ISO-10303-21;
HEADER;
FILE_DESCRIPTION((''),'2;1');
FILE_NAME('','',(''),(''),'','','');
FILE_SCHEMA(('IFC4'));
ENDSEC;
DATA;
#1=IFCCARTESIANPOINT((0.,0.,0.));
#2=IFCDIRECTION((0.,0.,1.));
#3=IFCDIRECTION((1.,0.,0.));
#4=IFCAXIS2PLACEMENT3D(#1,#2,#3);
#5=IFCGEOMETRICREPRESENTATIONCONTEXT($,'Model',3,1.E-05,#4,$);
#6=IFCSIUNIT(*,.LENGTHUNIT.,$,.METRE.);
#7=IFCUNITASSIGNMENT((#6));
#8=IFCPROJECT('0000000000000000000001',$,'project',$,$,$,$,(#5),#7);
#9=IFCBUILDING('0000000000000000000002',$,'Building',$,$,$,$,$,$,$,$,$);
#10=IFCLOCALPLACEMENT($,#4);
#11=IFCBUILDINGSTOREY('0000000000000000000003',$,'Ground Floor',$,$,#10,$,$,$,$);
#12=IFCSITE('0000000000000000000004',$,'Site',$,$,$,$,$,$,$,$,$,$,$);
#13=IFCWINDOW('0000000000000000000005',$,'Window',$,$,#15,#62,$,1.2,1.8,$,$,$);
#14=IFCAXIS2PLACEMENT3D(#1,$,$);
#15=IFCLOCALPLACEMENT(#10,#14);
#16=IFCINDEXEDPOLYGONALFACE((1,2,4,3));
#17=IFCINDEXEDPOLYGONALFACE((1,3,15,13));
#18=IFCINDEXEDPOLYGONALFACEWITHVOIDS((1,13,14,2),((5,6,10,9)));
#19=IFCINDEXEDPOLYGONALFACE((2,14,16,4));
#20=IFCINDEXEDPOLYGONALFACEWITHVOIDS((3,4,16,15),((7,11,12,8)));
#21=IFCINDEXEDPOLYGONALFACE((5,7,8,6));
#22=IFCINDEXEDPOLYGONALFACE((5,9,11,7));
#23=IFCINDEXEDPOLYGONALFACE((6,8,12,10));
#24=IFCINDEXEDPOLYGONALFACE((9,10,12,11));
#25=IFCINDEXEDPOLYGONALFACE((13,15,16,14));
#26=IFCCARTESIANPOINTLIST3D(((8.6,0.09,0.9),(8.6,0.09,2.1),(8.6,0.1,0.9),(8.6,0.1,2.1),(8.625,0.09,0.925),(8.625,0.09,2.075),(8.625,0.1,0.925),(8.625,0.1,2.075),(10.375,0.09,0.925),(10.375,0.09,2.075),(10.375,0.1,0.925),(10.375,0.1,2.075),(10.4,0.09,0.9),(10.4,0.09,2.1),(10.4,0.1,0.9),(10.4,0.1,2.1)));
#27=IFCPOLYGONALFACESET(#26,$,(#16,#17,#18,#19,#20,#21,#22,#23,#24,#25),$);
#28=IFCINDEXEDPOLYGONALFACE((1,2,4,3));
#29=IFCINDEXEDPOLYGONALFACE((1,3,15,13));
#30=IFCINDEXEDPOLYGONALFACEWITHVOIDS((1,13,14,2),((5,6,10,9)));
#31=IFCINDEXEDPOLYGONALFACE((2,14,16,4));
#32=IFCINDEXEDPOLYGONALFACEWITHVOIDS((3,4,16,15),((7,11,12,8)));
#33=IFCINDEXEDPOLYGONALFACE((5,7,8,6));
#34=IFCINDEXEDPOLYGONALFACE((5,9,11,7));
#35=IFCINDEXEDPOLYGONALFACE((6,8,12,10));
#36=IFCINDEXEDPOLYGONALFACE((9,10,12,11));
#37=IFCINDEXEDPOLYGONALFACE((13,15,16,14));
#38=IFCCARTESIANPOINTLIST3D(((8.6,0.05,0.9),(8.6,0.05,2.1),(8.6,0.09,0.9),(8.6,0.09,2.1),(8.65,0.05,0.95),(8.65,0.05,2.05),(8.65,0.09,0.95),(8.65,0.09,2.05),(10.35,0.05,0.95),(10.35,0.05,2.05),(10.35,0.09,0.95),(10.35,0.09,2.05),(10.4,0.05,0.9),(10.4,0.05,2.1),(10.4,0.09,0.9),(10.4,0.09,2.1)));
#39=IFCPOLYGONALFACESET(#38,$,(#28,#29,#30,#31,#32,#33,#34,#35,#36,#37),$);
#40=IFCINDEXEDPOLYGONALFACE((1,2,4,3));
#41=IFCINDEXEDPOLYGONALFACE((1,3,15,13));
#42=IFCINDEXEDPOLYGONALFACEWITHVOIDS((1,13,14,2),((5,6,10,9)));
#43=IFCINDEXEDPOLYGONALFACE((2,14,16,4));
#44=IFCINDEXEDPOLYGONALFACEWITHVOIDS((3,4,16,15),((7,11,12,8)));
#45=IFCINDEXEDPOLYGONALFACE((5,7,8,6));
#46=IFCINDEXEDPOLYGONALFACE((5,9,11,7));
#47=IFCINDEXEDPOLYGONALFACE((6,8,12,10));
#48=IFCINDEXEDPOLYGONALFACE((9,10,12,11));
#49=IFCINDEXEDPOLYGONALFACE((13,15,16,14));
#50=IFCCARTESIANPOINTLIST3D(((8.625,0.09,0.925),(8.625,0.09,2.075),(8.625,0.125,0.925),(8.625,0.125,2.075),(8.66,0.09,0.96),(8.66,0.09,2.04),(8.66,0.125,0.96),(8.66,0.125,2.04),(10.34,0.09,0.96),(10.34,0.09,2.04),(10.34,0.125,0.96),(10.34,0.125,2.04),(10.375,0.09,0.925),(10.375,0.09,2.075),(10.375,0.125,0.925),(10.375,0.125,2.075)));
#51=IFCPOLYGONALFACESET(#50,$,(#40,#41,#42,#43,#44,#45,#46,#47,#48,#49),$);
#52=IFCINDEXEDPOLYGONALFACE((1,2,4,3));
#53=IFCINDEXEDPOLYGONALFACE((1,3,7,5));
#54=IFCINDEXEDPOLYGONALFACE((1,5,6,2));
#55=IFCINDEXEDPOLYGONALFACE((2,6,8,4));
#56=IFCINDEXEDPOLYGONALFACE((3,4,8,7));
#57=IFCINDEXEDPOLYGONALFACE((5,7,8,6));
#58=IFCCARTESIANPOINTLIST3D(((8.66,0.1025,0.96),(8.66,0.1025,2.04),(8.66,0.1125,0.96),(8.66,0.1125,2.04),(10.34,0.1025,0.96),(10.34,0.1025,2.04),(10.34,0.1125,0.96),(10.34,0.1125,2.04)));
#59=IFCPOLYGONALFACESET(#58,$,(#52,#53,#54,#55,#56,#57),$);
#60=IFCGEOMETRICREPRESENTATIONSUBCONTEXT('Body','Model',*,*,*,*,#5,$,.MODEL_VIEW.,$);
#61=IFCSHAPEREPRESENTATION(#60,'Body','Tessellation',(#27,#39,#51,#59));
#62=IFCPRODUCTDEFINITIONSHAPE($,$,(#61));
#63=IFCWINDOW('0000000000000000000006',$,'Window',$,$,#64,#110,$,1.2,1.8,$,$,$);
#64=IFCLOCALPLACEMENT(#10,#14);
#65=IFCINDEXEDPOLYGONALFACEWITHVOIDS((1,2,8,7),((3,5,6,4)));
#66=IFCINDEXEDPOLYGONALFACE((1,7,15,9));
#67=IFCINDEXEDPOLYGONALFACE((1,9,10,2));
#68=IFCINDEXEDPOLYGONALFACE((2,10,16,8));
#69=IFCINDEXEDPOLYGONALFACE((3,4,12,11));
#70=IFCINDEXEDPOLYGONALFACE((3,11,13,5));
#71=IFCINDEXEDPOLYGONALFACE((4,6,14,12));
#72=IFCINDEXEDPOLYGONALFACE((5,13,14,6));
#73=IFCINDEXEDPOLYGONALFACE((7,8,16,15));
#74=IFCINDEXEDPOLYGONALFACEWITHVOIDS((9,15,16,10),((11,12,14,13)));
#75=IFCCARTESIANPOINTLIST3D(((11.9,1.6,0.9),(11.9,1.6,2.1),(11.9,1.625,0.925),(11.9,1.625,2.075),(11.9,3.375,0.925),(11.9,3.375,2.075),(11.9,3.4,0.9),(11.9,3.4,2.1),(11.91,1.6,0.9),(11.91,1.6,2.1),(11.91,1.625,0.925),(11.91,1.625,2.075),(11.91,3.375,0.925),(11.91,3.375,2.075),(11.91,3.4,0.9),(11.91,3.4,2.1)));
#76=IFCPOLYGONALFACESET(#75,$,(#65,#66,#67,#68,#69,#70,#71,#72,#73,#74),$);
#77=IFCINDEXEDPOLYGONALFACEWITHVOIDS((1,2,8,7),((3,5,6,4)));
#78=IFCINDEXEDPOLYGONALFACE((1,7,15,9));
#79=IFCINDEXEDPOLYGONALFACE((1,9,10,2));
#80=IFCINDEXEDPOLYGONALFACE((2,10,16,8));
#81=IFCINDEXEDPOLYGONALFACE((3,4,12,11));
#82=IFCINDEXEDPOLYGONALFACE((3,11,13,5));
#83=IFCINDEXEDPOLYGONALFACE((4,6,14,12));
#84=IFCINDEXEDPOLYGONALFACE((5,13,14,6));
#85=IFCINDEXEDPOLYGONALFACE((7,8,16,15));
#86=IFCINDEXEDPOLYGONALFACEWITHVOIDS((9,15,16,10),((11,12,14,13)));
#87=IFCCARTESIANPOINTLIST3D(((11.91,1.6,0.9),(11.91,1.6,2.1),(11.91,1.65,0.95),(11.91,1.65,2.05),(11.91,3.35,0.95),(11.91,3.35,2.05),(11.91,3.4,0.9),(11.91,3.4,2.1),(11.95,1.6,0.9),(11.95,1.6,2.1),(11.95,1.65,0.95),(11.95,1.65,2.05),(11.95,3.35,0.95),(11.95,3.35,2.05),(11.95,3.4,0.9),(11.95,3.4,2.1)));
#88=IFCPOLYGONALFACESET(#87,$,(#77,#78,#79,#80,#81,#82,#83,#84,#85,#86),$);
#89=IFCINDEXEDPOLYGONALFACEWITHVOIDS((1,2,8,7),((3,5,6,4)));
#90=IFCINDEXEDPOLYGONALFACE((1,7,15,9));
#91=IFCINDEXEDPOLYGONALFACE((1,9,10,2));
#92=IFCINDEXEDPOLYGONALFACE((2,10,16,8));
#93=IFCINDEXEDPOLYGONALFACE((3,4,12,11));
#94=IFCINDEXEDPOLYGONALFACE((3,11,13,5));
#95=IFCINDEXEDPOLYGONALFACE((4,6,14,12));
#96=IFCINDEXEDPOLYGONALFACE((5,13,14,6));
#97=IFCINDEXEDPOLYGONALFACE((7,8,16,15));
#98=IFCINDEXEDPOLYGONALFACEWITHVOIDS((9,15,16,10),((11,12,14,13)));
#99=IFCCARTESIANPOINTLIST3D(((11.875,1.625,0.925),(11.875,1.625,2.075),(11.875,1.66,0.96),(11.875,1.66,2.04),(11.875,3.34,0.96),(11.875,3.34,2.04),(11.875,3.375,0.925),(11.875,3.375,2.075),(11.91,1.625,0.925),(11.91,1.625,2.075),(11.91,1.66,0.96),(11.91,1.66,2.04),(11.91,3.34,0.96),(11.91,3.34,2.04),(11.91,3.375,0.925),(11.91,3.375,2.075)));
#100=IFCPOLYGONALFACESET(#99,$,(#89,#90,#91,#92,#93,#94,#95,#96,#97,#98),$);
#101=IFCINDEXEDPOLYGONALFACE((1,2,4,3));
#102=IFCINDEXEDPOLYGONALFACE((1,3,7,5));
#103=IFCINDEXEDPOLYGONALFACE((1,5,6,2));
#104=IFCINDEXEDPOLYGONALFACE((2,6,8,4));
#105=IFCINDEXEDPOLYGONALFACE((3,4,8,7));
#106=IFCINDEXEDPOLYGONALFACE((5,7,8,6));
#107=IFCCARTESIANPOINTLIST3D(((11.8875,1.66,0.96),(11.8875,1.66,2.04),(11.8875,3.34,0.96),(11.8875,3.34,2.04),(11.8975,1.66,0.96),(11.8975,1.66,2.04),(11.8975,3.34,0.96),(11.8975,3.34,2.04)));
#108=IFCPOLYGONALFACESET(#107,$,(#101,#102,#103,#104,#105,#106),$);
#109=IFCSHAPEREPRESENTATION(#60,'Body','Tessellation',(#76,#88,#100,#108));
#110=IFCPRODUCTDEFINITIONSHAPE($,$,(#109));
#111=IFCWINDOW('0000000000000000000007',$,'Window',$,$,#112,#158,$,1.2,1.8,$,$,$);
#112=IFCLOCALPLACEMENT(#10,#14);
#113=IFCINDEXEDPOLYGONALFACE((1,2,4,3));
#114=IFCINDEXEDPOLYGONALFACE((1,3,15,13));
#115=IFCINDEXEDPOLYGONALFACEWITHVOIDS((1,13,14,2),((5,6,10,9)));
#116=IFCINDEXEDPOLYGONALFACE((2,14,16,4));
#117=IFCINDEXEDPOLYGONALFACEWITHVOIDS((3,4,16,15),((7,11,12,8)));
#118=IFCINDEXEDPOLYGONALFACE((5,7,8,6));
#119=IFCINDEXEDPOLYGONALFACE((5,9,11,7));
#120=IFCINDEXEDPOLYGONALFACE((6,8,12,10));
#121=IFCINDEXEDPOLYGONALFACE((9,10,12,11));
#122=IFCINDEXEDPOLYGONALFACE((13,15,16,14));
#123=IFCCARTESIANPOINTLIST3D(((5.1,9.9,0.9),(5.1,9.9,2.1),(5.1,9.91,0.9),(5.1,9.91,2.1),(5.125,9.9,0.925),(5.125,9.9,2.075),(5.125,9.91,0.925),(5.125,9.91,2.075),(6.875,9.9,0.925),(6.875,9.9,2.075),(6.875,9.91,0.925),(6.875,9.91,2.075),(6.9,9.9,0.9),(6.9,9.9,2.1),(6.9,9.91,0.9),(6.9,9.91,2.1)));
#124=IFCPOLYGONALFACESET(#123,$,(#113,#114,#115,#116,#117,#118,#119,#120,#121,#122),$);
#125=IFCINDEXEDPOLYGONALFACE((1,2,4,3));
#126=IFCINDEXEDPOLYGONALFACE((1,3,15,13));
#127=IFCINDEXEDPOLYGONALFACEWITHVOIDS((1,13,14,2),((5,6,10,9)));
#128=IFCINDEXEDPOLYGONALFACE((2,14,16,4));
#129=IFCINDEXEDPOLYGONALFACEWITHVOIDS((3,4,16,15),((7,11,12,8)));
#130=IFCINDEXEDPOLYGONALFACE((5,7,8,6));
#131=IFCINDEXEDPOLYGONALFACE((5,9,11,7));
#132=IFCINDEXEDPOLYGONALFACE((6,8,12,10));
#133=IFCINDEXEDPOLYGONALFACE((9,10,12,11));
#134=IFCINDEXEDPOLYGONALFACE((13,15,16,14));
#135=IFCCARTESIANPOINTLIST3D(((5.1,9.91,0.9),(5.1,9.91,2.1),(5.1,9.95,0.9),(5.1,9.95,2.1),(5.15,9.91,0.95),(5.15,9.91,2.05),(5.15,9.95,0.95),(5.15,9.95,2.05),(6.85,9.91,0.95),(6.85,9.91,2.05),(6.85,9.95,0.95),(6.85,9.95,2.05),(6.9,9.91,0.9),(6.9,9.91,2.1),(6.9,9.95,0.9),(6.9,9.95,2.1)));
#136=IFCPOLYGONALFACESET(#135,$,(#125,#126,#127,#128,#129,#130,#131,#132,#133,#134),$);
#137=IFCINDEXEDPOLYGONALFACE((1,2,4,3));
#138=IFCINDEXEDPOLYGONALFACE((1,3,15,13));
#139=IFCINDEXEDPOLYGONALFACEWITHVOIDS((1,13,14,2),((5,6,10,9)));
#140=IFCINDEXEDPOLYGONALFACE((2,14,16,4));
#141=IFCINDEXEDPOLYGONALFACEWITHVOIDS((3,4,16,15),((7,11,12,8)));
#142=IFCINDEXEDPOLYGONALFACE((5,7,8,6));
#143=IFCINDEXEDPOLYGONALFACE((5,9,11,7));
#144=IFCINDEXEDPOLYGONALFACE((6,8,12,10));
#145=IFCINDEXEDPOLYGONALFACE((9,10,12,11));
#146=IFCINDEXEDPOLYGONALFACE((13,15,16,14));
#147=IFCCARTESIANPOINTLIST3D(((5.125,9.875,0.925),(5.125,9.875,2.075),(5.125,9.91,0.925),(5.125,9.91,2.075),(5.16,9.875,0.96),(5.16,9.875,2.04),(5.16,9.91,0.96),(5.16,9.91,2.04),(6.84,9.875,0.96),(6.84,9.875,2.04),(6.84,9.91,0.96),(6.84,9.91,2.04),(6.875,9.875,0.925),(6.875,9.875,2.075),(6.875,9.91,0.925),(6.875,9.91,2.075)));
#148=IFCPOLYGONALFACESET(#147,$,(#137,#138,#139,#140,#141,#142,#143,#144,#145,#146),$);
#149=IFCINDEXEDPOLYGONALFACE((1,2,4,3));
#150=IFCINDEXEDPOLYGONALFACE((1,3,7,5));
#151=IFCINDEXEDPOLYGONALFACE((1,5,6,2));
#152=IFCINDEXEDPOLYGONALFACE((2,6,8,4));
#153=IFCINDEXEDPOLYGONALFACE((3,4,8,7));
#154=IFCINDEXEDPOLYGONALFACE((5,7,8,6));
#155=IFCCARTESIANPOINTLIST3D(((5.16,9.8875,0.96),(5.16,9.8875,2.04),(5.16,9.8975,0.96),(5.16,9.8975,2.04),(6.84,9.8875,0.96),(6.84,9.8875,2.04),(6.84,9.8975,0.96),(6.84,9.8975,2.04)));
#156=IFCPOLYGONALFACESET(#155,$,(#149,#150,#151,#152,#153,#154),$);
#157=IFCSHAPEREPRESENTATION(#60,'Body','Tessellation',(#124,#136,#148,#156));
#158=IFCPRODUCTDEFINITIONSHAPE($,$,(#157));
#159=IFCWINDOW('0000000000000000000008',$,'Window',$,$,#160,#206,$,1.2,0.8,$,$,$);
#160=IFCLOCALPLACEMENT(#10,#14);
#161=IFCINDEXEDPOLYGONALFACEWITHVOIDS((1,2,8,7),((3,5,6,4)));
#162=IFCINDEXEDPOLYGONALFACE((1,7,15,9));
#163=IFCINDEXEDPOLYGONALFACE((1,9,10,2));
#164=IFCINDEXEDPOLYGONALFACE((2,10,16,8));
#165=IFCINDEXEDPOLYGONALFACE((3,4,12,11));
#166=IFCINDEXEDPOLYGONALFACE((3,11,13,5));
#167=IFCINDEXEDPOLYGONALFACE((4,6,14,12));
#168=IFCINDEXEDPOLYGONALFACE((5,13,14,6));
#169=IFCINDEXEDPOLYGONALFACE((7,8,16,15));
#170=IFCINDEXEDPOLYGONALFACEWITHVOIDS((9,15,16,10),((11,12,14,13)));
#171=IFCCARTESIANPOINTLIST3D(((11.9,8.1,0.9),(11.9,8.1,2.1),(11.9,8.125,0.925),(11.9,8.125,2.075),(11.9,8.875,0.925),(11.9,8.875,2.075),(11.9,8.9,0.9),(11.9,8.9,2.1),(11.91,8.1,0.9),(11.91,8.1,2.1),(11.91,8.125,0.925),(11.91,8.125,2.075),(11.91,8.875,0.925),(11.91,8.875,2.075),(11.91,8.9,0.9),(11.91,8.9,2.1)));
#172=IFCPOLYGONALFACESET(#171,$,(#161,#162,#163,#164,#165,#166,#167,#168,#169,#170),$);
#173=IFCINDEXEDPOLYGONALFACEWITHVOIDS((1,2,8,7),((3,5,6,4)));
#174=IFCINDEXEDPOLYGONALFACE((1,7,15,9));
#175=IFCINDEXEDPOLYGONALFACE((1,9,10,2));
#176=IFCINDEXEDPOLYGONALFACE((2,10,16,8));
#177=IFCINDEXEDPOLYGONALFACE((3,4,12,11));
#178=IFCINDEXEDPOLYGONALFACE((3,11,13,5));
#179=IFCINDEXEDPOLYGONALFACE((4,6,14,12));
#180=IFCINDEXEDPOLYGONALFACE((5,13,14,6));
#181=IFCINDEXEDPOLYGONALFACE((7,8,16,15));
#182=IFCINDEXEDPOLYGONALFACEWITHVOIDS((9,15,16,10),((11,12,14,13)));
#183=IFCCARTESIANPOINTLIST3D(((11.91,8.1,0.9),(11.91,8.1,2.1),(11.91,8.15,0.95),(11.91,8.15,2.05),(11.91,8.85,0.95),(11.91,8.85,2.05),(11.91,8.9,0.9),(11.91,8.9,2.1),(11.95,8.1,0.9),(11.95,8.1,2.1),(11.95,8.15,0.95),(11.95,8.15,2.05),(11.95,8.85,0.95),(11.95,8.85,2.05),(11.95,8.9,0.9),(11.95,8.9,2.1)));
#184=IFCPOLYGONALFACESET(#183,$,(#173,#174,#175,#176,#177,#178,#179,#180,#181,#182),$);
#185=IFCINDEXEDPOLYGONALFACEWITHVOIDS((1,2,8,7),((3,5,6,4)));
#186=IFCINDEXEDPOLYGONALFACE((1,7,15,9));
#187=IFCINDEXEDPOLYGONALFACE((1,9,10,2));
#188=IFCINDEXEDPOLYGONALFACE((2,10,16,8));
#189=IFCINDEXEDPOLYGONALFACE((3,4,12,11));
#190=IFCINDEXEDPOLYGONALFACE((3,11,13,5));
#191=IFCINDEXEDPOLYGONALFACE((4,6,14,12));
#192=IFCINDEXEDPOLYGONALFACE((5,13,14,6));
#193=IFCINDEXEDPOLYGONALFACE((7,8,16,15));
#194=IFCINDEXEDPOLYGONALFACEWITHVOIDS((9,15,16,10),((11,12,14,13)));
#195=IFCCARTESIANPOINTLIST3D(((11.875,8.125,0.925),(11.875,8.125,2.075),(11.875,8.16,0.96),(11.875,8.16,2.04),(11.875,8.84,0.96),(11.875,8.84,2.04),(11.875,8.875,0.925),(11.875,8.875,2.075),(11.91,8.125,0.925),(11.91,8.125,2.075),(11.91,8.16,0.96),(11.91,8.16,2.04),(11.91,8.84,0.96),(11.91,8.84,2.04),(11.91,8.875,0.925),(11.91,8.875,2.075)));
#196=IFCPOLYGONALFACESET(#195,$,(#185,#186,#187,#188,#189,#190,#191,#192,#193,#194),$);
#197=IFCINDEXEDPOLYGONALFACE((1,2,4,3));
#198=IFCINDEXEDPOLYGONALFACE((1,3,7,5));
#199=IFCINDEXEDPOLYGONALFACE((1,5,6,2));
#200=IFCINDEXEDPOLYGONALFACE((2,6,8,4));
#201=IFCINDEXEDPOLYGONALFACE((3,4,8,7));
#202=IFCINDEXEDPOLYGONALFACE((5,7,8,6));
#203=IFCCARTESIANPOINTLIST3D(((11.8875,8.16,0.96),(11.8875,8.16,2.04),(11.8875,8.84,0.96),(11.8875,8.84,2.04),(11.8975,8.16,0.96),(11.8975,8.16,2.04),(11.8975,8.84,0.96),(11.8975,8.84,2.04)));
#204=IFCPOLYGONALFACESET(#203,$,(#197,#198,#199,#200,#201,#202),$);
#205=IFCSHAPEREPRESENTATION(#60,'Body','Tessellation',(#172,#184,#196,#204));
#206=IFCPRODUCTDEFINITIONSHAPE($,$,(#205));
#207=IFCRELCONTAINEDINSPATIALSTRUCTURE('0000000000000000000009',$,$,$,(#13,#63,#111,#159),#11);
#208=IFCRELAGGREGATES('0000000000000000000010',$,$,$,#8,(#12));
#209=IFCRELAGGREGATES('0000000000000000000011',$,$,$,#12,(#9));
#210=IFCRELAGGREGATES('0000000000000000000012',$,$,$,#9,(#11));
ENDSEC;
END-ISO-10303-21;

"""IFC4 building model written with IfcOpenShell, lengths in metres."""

from ifc_helpers import new_model, si_unit, frame, origin_with_axes, place, context, subcontext, project, spatial, line, indexed_curve, outline, extrude, element, save


model = new_model("IFC4")

# Units and contexts
model_context = context("Model", 3, precision=1e-05, world=origin_with_axes())
body_context = subcontext(model_context, "Body", "Model", "MODEL_VIEW")
ifc_project = project(units=[si_unit("LENGTHUNIT", "METRE")], contexts=[model_context])

# Site, building, storey
site = spatial("IfcSite", under=ifc_project, Name="Site")
building = spatial("IfcBuilding", under=site, Name="Building")
storey_placement = place(None, origin_with_axes())
storey = spatial("IfcBuildingStorey", under=building, at=storey_placement, Name="Ground Floor")

# Windows
for number, where, z_axis, x_axis, name in (
    (1, (8.6, 0.0, 0.9), (0.0, 0.0, 1.0), (1.0, 0.0, 0.0), "Window"),
    (2, (12.0, 1.6, 0.9), (0.0, 0.0, 1.0), (0.0, 1.0, 0.0), "Window"),
    (3, (6.9, 10.0, 0.9), (0.0, 0.0, 1.0), (-1.0, 0.0, 0.0), "Window"),
):
    element("IfcWindow", number, at=place(storey_placement, frame(where, z_axis=z_axis, x_axis=x_axis)), inside=storey, Name=name, OverallHeight=1.2, OverallWidth=1.8, context=body_context, shape_type="SweptSolid", body=[
        extrude(outline(indexed_curve([(0.0, 0.0), (1.8, 0.0), (1.8, 1.2), (0.0, 1.2)], segments=[line(1, 2, 3, 4, 1)]), holes=[indexed_curve([(0.025, 0.025), (1.775, 0.025), (1.775, 1.175), (0.025, 1.175)], segments=[line(1, 2, 3, 4, 1)])]), frame((0.0, 0.09, 0.0), z_axis=(0.0, -1.0, 0.0), x_axis=(1.0, 0.0, 0.0)), (0.0, 0.0, -1.0), 0.01),
        extrude(outline(indexed_curve([(0.0, 0.0), (1.8, 0.0), (1.8, 1.2), (0.0, 1.2)], segments=[line(1, 2, 3, 4, 1)]), holes=[indexed_curve([(0.05, 0.05), (1.75, 0.05), (1.75, 1.15), (0.05, 1.15)], segments=[line(1, 2, 3, 4, 1)])]), frame((0.0, 0.05, 0.0), z_axis=(0.0, -1.0, 0.0), x_axis=(1.0, 0.0, 0.0)), (0.0, 0.0, -1.0), 0.04),
        extrude(outline(indexed_curve([(0.0, 0.0), (1.75, 0.0), (1.75, 1.15), (0.0, 1.15)], segments=[line(1, 2, 3, 4, 1)]), holes=[indexed_curve([(0.035, 0.035), (1.715, 0.035), (1.715, 1.115), (0.035, 1.115)], segments=[line(1, 2, 3, 4, 1)])]), frame((0.025, 0.09, 0.025), z_axis=(0.0, -1.0, 0.0), x_axis=(1.0, 0.0, 0.0)), (0.0, 0.0, -1.0), 0.035),
        extrude(outline(indexed_curve([(0.035, 0.035), (1.715, 0.035), (1.715, 1.115), (0.035, 1.115)], segments=[line(1, 2, 3, 4, 1)])), frame((0.025, 0.1025, 0.025), z_axis=(0.0, -1.0, 0.0), x_axis=(1.0, 0.0, 0.0)), (0.0, 0.0, -1.0), 0.01),
    ])
for number, where, z_axis, x_axis, name in (
    (4, (12.0, 8.1, 0.9), (0.0, 0.0, 1.0), (0.0, 1.0, 0.0), "Window"),
):
    element("IfcWindow", number, at=place(storey_placement, frame(where, z_axis=z_axis, x_axis=x_axis)), inside=storey, Name=name, OverallHeight=1.2, OverallWidth=0.8, context=body_context, shape_type="SweptSolid", body=[
        extrude(outline(indexed_curve([(0.0, 0.0), (0.8, 0.0), (0.8, 1.2), (0.0, 1.2)], segments=[line(1, 2, 3, 4, 1)]), holes=[indexed_curve([(0.025, 0.025), (0.775, 0.025), (0.775, 1.175), (0.025, 1.175)], segments=[line(1, 2, 3, 4, 1)])]), frame((0.0, 0.09, 0.0), z_axis=(0.0, -1.0, 0.0), x_axis=(1.0, 0.0, 0.0)), (0.0, 0.0, -1.0), 0.01),
        extrude(outline(indexed_curve([(0.0, 0.0), (0.8, 0.0), (0.8, 1.2), (0.0, 1.2)], segments=[line(1, 2, 3, 4, 1)]), holes=[indexed_curve([(0.05, 0.05), (0.75, 0.05), (0.75, 1.15), (0.05, 1.15)], segments=[line(1, 2, 3, 4, 1)])]), frame((0.0, 0.05, 0.0), z_axis=(0.0, -1.0, 0.0), x_axis=(1.0, 0.0, 0.0)), (0.0, 0.0, -1.0), 0.04),
        extrude(outline(indexed_curve([(0.0, 0.0), (0.75, 0.0), (0.75, 1.15), (0.0, 1.15)], segments=[line(1, 2, 3, 4, 1)]), holes=[indexed_curve([(0.035, 0.035), (0.715, 0.035), (0.715, 1.115), (0.035, 1.115)], segments=[line(1, 2, 3, 4, 1)])]), frame((0.025, 0.09, 0.025), z_axis=(0.0, -1.0, 0.0), x_axis=(1.0, 0.0, 0.0)), (0.0, 0.0, -1.0), 0.035),
        extrude(outline(indexed_curve([(0.035, 0.035), (0.715, 0.035), (0.715, 1.115), (0.035, 1.115)], segments=[line(1, 2, 3, 4, 1)])), frame((0.025, 0.1025, 0.025), z_axis=(0.0, -1.0, 0.0), x_axis=(1.0, 0.0, 0.0)), (0.0, 0.0, -1.0), 0.01),
    ])

save(model, "model.ifc")
